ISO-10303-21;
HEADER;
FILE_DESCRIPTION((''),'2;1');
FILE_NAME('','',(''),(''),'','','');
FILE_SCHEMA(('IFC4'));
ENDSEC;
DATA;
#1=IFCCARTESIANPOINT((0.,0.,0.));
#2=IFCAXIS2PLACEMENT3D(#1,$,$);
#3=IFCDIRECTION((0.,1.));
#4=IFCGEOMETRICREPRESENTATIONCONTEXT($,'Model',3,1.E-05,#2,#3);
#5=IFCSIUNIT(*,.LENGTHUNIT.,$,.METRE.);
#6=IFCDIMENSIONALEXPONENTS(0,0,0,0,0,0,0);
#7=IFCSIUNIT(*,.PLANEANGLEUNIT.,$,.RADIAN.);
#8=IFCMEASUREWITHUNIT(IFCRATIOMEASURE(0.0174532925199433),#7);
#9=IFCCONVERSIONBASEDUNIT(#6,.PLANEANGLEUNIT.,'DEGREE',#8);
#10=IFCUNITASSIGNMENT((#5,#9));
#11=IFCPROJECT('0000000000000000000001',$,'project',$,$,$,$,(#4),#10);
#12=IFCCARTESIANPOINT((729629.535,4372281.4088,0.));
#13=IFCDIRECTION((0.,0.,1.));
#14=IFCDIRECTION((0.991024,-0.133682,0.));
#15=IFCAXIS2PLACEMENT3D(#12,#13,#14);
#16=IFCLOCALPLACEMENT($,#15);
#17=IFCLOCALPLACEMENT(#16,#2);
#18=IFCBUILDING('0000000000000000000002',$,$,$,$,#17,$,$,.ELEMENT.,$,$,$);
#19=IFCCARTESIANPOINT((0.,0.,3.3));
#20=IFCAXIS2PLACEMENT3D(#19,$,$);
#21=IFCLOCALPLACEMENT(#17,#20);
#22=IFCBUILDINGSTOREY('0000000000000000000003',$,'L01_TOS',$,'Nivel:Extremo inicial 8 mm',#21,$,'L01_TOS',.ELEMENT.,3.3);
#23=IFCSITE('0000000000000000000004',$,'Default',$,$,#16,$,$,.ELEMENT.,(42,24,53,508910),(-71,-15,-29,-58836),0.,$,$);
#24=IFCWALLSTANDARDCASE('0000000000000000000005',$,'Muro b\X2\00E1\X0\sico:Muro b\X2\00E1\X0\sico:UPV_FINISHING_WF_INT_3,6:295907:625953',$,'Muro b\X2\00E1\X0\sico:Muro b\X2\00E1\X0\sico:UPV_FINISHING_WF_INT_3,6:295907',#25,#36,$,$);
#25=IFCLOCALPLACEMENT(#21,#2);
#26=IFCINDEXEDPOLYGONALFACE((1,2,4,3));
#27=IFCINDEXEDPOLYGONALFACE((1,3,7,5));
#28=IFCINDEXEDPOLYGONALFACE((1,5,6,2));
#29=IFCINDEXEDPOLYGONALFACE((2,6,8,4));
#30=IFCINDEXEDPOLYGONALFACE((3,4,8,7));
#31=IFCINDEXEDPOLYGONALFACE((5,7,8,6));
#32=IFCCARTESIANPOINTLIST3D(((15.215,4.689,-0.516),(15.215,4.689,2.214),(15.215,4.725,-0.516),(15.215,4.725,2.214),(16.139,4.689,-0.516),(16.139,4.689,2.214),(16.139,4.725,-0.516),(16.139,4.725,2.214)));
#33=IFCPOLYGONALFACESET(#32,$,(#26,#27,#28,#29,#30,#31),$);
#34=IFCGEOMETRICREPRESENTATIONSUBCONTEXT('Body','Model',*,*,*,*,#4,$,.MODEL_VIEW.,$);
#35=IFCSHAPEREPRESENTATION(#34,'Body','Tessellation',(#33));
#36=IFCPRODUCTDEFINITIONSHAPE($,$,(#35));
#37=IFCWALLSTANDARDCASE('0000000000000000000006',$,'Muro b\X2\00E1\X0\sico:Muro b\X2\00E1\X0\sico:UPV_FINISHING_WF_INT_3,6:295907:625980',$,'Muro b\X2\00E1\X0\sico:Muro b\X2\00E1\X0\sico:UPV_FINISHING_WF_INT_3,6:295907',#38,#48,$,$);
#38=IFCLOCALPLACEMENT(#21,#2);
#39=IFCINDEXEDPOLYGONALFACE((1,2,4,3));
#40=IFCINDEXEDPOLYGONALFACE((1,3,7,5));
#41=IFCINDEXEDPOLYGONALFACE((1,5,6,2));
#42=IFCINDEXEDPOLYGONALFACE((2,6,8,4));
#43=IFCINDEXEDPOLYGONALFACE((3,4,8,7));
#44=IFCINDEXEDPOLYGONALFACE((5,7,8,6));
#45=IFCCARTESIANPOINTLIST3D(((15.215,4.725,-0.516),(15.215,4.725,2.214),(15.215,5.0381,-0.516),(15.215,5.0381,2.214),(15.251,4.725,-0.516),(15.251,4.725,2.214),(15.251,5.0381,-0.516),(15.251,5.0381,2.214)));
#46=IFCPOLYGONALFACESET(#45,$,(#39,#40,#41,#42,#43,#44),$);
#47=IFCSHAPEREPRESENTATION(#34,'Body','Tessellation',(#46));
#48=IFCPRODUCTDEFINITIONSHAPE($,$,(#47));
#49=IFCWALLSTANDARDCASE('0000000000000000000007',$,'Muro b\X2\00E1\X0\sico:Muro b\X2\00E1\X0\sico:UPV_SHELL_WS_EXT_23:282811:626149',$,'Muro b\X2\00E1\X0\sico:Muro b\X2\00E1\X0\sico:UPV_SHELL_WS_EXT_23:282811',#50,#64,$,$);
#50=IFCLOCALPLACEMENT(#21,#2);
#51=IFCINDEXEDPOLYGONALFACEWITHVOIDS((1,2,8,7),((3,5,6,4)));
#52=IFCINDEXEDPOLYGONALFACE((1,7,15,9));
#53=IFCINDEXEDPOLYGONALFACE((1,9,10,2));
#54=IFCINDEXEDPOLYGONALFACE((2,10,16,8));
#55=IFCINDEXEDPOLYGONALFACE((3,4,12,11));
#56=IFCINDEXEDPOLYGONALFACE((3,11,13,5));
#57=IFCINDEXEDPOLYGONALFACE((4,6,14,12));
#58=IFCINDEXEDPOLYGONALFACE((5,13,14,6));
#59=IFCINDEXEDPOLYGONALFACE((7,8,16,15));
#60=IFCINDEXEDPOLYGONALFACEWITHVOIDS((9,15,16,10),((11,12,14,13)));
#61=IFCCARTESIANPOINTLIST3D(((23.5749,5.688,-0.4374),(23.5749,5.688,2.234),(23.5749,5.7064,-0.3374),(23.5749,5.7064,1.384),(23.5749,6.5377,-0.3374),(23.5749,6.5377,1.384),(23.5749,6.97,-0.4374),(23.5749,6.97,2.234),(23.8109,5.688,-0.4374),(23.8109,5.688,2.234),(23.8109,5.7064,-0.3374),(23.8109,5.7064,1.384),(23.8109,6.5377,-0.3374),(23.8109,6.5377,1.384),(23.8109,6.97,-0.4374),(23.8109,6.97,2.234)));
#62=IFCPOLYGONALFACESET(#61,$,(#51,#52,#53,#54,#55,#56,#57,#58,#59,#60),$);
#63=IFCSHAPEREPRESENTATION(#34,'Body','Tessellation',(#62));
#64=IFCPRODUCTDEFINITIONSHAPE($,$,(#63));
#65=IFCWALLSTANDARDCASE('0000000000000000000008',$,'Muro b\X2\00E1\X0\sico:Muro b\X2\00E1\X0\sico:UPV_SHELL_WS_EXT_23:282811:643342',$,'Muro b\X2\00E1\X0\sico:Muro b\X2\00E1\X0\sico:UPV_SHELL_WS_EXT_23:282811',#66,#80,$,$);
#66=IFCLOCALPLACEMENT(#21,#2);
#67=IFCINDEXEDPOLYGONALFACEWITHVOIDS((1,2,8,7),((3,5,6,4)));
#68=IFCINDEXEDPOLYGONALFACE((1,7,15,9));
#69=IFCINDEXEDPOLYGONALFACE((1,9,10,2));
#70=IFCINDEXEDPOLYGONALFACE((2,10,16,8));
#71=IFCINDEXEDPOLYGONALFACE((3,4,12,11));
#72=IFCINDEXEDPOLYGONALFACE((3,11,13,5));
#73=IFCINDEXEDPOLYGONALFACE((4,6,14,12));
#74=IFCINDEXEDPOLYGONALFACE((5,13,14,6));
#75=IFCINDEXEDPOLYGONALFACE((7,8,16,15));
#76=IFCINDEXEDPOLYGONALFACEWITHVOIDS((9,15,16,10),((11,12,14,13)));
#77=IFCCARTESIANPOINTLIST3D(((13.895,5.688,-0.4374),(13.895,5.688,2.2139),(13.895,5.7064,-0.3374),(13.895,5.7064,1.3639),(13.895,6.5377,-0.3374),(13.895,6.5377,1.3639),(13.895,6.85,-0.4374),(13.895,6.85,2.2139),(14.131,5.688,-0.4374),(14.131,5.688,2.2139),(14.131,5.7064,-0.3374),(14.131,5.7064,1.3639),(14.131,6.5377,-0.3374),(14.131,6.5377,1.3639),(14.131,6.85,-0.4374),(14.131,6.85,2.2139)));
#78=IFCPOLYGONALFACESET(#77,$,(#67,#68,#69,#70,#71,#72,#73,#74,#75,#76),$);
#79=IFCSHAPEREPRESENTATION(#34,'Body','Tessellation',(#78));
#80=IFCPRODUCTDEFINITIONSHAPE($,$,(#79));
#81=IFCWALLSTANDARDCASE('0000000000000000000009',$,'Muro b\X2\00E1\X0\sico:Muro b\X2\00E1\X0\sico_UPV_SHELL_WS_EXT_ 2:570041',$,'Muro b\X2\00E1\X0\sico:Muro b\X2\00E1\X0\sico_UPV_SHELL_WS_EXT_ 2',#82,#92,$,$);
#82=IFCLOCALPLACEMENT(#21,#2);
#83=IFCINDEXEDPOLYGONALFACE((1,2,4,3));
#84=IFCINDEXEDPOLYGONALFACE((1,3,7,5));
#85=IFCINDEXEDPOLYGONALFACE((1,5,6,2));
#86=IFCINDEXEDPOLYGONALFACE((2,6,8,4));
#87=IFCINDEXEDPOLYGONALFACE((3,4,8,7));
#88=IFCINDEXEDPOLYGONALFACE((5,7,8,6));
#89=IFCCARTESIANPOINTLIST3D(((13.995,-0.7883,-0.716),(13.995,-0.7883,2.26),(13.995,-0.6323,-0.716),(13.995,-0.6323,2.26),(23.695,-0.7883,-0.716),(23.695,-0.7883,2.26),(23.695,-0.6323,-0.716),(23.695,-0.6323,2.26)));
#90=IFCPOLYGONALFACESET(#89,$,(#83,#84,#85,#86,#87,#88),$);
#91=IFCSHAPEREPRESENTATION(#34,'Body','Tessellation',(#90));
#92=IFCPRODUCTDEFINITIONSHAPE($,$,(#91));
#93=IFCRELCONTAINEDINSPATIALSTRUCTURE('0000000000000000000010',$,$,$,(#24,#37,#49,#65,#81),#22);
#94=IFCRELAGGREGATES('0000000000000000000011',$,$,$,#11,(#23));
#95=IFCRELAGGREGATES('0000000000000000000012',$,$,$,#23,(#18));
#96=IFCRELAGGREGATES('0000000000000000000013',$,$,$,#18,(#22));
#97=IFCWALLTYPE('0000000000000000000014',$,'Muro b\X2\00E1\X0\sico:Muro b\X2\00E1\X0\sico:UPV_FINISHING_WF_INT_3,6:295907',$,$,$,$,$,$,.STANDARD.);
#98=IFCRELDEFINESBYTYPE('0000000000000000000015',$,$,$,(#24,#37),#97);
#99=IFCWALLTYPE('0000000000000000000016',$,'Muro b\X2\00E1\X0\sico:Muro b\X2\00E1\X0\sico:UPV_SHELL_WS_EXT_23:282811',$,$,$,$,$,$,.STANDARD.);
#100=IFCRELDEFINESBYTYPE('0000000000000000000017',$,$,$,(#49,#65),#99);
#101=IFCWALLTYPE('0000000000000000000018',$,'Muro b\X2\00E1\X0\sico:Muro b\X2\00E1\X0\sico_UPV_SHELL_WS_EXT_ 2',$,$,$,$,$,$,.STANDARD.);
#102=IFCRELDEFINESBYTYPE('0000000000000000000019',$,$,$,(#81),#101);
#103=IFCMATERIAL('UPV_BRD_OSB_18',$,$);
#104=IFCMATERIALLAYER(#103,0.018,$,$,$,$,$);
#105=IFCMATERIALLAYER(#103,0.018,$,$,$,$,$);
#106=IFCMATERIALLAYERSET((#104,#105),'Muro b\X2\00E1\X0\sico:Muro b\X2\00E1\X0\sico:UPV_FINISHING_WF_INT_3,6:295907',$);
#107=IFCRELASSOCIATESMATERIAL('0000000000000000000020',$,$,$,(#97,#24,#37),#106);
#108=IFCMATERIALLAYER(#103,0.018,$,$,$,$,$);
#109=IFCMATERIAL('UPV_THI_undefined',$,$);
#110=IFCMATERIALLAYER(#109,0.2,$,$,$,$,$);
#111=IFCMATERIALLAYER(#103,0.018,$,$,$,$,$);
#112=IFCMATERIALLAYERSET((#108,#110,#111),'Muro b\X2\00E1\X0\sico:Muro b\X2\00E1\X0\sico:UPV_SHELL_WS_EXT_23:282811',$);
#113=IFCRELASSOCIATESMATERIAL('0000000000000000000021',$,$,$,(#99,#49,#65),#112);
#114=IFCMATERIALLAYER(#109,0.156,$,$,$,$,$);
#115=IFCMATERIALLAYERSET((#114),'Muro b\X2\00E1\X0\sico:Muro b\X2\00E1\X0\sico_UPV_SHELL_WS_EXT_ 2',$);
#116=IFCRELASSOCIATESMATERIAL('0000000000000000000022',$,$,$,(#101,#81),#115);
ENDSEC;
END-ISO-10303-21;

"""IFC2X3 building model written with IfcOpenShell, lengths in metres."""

from ifc_helpers import new_model, entity, si_unit, converted_unit, direction, frame, frame_2d, origin, place, context, subcontext, project, spatial, rectangle, extrude, material, layer, layer_set, layer_usage, type_object, element, save


model = new_model("IFC2X3")

# Units and contexts
model_context = context("Model", 3, precision=1e-05, world=origin(), true_north=direction((0.0, 1.0)))
body_context = subcontext(model_context, "Body", "Model", "MODEL_VIEW")
ifc_project = project(units=[si_unit("LENGTHUNIT", "METRE"), converted_unit("PLANEANGLEUNIT", "DEGREE", entity("IfcRatioMeasure", 0.0174532925199433), si_unit("PLANEANGLEUNIT", "RADIAN"), dimensions=[0, 0, 0, 0, 0, 0, 0])], contexts=[model_context])

# Site, building, storey
site_placement = place(None, frame((729629.535, 4372281.4088, 0.0), z_axis=(0.0, 0.0, 1.0), x_axis=(0.991024, -0.133682, 0.0)))
site = spatial("IfcSite", under=ifc_project, at=site_placement, Name="Default", CompositionType="ELEMENT", RefLatitude=(42, 24, 53, 508910), RefLongitude=(-71, -15, -29, -58836), RefElevation=0.0)
building_placement = place(site_placement, origin())
building = spatial("IfcBuilding", under=site, at=building_placement, CompositionType="ELEMENT")
storey_placement = place(building_placement, frame((0.0, 0.0, 3.3)))
storey = spatial("IfcBuildingStorey", under=building, at=storey_placement, Name="L01_TOS", ObjectType="Nivel:Extremo inicial 8 mm", LongName="L01_TOS", CompositionType="ELEMENT", Elevation=3.3)

# Walls
ifc_material_1 = material(Name="UPV_BRD_OSB_18")
ifc_layer_1 = layer(ifc_material_1, 0.018)
ifc_layer_2 = layer(ifc_material_1, 0.018)
ifc_layer_set_1 = layer_set([ifc_layer_1, ifc_layer_2], Name="Muro básico:Muro básico:UPV_FINISHING_WF_INT_3,6:295907")
wall_type_1 = type_object("IfcWallType", Name="Muro básico:Muro básico:UPV_FINISHING_WF_INT_3,6:295907", PredefinedType="STANDARD", material=ifc_layer_set_1)
ifc_layer_usage_1 = layer_usage(ifc_layer_set_1, "AXIS2", "NEGATIVE", 0.018)
wall_1_placement = place(storey_placement, frame((16.139, 4.707, -0.516), z_axis=(0.0, 0.0, 1.0), x_axis=(-1.0, -0.000012, 0.0)))
element("IfcWallStandardCase", 1, at=wall_1_placement, inside=storey, type_object=wall_type_1, material=ifc_layer_usage_1, Name="Muro básico:Muro básico:UPV_FINISHING_WF_INT_3,6:295907:625953", ObjectType="Muro básico:Muro básico:UPV_FINISHING_WF_INT_3,6:295907", context=body_context, shape_type="SweptSolid", body=[
    extrude(rectangle(XDim=0.924, YDim=0.036, at=frame_2d((0.462, 0.0), x_axis=(-1.0, 0.0))), origin(), (0.0, 0.0, 1.0), 2.73),
])
ifc_layer_usage_2 = layer_usage(ifc_layer_set_1, "AXIS2", "NEGATIVE", 0.018)
wall_2_placement = place(storey_placement, frame((15.233, 4.725, -0.516), z_axis=(0.0, 0.0, 1.0), x_axis=(0.0, 1.0, 0.0)))
element("IfcWallStandardCase", 2, at=wall_2_placement, inside=storey, type_object=wall_type_1, material=ifc_layer_usage_2, Name="Muro básico:Muro básico:UPV_FINISHING_WF_INT_3,6:295907:625980", ObjectType="Muro básico:Muro básico:UPV_FINISHING_WF_INT_3,6:295907", context=body_context, shape_type="SweptSolid", body=[
    extrude(rectangle(XDim=0.313, YDim=0.036, at=frame_2d((0.1565, 0.0), x_axis=(-1.0, 0.0))), origin(), (0.0, 0.0, 1.0), 2.73),
])

# Walls, openings
ifc_layer_3 = layer(ifc_material_1, 0.018)
ifc_material_2 = material(Name="UPV_THI_undefined")
ifc_layer_4 = layer(ifc_material_2, 0.2)
ifc_layer_5 = layer(ifc_material_1, 0.018)
ifc_layer_set_2 = layer_set([ifc_layer_3, ifc_layer_4, ifc_layer_5], Name="Muro básico:Muro básico:UPV_SHELL_WS_EXT_23:282811")
ifc_layer_usage_3 = layer_usage(ifc_layer_set_2, "AXIS2", "NEGATIVE", 0.118)
wall_type_2 = type_object("IfcWallType", Name="Muro básico:Muro básico:UPV_SHELL_WS_EXT_23:282811", PredefinedType="STANDARD", material=ifc_layer_set_2)
wall_3_placement = place(storey_placement, frame((23.6929, 6.97, -0.4374), z_axis=(0.0, 0.0, 1.0), x_axis=(0.0, -1.0, 0.0)))
wall_3 = element("IfcWallStandardCase", 3, at=wall_3_placement, inside=storey, type_object=wall_type_2, material=ifc_layer_usage_3, Name="Muro básico:Muro básico:UPV_SHELL_WS_EXT_23:282811:626149", ObjectType="Muro básico:Muro básico:UPV_SHELL_WS_EXT_23:282811", context=body_context, shape_type="SweptSolid", body=[
    extrude(rectangle(XDim=1.282, YDim=0.236, at=frame_2d((0.641, 0.0), x_axis=(-1.0, 0.0))), origin(), (0.0, 0.0, 1.0), 2.6714),
])
opening_1_placement = place(wall_3_placement, origin())
element("IfcOpeningElement", 4, at=opening_1_placement, cuts=wall_3, ObjectType="Opening", context=body_context, shape_type="SweptSolid", body=[
    extrude(rectangle(XDim=1.7214, YDim=0.8314, at=frame_2d((0.0, 0.0), x_axis=(0.0, 1.0))), frame((0.848, 0.118, 0.9607), z_axis=(0.0, -1.0, 0.0), x_axis=(-1.0, 0.0, 0.0)), (0.0, 0.0, 1.0), 0.236),
])
ifc_layer_usage_4 = layer_usage(ifc_layer_set_2, "AXIS2", "POSITIVE", -0.118)
wall_4_placement = place(storey_placement, frame((14.013, 6.85, -0.4374), z_axis=(0.0, 0.0, 1.0), x_axis=(0.0, -1.0, 0.0)))
wall_4 = element("IfcWallStandardCase", 5, at=wall_4_placement, inside=storey, type_object=wall_type_2, material=ifc_layer_usage_4, Name="Muro básico:Muro básico:UPV_SHELL_WS_EXT_23:282811:643342", ObjectType="Muro básico:Muro básico:UPV_SHELL_WS_EXT_23:282811", context=body_context, shape_type="SweptSolid", body=[
    extrude(rectangle(XDim=1.162, YDim=0.236, at=frame_2d((0.581, 0.0), x_axis=(-1.0, 0.0))), origin(), (0.0, 0.0, 1.0), 2.6513),
])
opening_2_placement = place(wall_4_placement, origin())
element("IfcOpeningElement", 6, at=opening_2_placement, cuts=wall_4, ObjectType="Opening", context=body_context, shape_type="SweptSolid", body=[
    extrude(rectangle(XDim=1.7013, YDim=0.8314, at=frame_2d((0.0, 0.0), x_axis=(0.0, 1.0))), frame((0.728, 0.118, 0.9507), z_axis=(0.0, -1.0, 0.0), x_axis=(-1.0, 0.0, 0.0)), (0.0, 0.0, 1.0), 0.236),
])

# Wall
ifc_layer_6 = layer(ifc_material_2, 0.156)
ifc_layer_set_3 = layer_set([ifc_layer_6], Name="Muro básico:Muro básico_UPV_SHELL_WS_EXT_ 2")
ifc_layer_usage_5 = layer_usage(ifc_layer_set_3, "AXIS2", "NEGATIVE", 0.078)
wall_type_3 = type_object("IfcWallType", Name="Muro básico:Muro básico_UPV_SHELL_WS_EXT_ 2", PredefinedType="STANDARD", material=ifc_layer_set_3)
wall_5_placement = place(storey_placement, frame((13.995, -0.7103, -0.716)))
element("IfcWallStandardCase", 7, at=wall_5_placement, inside=storey, type_object=wall_type_3, material=ifc_layer_usage_5, Name="Muro básico:Muro básico_UPV_SHELL_WS_EXT_ 2:570041", ObjectType="Muro básico:Muro básico_UPV_SHELL_WS_EXT_ 2", context=body_context, shape_type="SweptSolid", body=[
    extrude(rectangle(XDim=9.7, YDim=0.156, at=frame_2d((4.85, 0.0), x_axis=(-1.0, 0.0))), origin(), (0.0, 0.0, 1.0), 2.976),
])

save(model, "model.ifc")
